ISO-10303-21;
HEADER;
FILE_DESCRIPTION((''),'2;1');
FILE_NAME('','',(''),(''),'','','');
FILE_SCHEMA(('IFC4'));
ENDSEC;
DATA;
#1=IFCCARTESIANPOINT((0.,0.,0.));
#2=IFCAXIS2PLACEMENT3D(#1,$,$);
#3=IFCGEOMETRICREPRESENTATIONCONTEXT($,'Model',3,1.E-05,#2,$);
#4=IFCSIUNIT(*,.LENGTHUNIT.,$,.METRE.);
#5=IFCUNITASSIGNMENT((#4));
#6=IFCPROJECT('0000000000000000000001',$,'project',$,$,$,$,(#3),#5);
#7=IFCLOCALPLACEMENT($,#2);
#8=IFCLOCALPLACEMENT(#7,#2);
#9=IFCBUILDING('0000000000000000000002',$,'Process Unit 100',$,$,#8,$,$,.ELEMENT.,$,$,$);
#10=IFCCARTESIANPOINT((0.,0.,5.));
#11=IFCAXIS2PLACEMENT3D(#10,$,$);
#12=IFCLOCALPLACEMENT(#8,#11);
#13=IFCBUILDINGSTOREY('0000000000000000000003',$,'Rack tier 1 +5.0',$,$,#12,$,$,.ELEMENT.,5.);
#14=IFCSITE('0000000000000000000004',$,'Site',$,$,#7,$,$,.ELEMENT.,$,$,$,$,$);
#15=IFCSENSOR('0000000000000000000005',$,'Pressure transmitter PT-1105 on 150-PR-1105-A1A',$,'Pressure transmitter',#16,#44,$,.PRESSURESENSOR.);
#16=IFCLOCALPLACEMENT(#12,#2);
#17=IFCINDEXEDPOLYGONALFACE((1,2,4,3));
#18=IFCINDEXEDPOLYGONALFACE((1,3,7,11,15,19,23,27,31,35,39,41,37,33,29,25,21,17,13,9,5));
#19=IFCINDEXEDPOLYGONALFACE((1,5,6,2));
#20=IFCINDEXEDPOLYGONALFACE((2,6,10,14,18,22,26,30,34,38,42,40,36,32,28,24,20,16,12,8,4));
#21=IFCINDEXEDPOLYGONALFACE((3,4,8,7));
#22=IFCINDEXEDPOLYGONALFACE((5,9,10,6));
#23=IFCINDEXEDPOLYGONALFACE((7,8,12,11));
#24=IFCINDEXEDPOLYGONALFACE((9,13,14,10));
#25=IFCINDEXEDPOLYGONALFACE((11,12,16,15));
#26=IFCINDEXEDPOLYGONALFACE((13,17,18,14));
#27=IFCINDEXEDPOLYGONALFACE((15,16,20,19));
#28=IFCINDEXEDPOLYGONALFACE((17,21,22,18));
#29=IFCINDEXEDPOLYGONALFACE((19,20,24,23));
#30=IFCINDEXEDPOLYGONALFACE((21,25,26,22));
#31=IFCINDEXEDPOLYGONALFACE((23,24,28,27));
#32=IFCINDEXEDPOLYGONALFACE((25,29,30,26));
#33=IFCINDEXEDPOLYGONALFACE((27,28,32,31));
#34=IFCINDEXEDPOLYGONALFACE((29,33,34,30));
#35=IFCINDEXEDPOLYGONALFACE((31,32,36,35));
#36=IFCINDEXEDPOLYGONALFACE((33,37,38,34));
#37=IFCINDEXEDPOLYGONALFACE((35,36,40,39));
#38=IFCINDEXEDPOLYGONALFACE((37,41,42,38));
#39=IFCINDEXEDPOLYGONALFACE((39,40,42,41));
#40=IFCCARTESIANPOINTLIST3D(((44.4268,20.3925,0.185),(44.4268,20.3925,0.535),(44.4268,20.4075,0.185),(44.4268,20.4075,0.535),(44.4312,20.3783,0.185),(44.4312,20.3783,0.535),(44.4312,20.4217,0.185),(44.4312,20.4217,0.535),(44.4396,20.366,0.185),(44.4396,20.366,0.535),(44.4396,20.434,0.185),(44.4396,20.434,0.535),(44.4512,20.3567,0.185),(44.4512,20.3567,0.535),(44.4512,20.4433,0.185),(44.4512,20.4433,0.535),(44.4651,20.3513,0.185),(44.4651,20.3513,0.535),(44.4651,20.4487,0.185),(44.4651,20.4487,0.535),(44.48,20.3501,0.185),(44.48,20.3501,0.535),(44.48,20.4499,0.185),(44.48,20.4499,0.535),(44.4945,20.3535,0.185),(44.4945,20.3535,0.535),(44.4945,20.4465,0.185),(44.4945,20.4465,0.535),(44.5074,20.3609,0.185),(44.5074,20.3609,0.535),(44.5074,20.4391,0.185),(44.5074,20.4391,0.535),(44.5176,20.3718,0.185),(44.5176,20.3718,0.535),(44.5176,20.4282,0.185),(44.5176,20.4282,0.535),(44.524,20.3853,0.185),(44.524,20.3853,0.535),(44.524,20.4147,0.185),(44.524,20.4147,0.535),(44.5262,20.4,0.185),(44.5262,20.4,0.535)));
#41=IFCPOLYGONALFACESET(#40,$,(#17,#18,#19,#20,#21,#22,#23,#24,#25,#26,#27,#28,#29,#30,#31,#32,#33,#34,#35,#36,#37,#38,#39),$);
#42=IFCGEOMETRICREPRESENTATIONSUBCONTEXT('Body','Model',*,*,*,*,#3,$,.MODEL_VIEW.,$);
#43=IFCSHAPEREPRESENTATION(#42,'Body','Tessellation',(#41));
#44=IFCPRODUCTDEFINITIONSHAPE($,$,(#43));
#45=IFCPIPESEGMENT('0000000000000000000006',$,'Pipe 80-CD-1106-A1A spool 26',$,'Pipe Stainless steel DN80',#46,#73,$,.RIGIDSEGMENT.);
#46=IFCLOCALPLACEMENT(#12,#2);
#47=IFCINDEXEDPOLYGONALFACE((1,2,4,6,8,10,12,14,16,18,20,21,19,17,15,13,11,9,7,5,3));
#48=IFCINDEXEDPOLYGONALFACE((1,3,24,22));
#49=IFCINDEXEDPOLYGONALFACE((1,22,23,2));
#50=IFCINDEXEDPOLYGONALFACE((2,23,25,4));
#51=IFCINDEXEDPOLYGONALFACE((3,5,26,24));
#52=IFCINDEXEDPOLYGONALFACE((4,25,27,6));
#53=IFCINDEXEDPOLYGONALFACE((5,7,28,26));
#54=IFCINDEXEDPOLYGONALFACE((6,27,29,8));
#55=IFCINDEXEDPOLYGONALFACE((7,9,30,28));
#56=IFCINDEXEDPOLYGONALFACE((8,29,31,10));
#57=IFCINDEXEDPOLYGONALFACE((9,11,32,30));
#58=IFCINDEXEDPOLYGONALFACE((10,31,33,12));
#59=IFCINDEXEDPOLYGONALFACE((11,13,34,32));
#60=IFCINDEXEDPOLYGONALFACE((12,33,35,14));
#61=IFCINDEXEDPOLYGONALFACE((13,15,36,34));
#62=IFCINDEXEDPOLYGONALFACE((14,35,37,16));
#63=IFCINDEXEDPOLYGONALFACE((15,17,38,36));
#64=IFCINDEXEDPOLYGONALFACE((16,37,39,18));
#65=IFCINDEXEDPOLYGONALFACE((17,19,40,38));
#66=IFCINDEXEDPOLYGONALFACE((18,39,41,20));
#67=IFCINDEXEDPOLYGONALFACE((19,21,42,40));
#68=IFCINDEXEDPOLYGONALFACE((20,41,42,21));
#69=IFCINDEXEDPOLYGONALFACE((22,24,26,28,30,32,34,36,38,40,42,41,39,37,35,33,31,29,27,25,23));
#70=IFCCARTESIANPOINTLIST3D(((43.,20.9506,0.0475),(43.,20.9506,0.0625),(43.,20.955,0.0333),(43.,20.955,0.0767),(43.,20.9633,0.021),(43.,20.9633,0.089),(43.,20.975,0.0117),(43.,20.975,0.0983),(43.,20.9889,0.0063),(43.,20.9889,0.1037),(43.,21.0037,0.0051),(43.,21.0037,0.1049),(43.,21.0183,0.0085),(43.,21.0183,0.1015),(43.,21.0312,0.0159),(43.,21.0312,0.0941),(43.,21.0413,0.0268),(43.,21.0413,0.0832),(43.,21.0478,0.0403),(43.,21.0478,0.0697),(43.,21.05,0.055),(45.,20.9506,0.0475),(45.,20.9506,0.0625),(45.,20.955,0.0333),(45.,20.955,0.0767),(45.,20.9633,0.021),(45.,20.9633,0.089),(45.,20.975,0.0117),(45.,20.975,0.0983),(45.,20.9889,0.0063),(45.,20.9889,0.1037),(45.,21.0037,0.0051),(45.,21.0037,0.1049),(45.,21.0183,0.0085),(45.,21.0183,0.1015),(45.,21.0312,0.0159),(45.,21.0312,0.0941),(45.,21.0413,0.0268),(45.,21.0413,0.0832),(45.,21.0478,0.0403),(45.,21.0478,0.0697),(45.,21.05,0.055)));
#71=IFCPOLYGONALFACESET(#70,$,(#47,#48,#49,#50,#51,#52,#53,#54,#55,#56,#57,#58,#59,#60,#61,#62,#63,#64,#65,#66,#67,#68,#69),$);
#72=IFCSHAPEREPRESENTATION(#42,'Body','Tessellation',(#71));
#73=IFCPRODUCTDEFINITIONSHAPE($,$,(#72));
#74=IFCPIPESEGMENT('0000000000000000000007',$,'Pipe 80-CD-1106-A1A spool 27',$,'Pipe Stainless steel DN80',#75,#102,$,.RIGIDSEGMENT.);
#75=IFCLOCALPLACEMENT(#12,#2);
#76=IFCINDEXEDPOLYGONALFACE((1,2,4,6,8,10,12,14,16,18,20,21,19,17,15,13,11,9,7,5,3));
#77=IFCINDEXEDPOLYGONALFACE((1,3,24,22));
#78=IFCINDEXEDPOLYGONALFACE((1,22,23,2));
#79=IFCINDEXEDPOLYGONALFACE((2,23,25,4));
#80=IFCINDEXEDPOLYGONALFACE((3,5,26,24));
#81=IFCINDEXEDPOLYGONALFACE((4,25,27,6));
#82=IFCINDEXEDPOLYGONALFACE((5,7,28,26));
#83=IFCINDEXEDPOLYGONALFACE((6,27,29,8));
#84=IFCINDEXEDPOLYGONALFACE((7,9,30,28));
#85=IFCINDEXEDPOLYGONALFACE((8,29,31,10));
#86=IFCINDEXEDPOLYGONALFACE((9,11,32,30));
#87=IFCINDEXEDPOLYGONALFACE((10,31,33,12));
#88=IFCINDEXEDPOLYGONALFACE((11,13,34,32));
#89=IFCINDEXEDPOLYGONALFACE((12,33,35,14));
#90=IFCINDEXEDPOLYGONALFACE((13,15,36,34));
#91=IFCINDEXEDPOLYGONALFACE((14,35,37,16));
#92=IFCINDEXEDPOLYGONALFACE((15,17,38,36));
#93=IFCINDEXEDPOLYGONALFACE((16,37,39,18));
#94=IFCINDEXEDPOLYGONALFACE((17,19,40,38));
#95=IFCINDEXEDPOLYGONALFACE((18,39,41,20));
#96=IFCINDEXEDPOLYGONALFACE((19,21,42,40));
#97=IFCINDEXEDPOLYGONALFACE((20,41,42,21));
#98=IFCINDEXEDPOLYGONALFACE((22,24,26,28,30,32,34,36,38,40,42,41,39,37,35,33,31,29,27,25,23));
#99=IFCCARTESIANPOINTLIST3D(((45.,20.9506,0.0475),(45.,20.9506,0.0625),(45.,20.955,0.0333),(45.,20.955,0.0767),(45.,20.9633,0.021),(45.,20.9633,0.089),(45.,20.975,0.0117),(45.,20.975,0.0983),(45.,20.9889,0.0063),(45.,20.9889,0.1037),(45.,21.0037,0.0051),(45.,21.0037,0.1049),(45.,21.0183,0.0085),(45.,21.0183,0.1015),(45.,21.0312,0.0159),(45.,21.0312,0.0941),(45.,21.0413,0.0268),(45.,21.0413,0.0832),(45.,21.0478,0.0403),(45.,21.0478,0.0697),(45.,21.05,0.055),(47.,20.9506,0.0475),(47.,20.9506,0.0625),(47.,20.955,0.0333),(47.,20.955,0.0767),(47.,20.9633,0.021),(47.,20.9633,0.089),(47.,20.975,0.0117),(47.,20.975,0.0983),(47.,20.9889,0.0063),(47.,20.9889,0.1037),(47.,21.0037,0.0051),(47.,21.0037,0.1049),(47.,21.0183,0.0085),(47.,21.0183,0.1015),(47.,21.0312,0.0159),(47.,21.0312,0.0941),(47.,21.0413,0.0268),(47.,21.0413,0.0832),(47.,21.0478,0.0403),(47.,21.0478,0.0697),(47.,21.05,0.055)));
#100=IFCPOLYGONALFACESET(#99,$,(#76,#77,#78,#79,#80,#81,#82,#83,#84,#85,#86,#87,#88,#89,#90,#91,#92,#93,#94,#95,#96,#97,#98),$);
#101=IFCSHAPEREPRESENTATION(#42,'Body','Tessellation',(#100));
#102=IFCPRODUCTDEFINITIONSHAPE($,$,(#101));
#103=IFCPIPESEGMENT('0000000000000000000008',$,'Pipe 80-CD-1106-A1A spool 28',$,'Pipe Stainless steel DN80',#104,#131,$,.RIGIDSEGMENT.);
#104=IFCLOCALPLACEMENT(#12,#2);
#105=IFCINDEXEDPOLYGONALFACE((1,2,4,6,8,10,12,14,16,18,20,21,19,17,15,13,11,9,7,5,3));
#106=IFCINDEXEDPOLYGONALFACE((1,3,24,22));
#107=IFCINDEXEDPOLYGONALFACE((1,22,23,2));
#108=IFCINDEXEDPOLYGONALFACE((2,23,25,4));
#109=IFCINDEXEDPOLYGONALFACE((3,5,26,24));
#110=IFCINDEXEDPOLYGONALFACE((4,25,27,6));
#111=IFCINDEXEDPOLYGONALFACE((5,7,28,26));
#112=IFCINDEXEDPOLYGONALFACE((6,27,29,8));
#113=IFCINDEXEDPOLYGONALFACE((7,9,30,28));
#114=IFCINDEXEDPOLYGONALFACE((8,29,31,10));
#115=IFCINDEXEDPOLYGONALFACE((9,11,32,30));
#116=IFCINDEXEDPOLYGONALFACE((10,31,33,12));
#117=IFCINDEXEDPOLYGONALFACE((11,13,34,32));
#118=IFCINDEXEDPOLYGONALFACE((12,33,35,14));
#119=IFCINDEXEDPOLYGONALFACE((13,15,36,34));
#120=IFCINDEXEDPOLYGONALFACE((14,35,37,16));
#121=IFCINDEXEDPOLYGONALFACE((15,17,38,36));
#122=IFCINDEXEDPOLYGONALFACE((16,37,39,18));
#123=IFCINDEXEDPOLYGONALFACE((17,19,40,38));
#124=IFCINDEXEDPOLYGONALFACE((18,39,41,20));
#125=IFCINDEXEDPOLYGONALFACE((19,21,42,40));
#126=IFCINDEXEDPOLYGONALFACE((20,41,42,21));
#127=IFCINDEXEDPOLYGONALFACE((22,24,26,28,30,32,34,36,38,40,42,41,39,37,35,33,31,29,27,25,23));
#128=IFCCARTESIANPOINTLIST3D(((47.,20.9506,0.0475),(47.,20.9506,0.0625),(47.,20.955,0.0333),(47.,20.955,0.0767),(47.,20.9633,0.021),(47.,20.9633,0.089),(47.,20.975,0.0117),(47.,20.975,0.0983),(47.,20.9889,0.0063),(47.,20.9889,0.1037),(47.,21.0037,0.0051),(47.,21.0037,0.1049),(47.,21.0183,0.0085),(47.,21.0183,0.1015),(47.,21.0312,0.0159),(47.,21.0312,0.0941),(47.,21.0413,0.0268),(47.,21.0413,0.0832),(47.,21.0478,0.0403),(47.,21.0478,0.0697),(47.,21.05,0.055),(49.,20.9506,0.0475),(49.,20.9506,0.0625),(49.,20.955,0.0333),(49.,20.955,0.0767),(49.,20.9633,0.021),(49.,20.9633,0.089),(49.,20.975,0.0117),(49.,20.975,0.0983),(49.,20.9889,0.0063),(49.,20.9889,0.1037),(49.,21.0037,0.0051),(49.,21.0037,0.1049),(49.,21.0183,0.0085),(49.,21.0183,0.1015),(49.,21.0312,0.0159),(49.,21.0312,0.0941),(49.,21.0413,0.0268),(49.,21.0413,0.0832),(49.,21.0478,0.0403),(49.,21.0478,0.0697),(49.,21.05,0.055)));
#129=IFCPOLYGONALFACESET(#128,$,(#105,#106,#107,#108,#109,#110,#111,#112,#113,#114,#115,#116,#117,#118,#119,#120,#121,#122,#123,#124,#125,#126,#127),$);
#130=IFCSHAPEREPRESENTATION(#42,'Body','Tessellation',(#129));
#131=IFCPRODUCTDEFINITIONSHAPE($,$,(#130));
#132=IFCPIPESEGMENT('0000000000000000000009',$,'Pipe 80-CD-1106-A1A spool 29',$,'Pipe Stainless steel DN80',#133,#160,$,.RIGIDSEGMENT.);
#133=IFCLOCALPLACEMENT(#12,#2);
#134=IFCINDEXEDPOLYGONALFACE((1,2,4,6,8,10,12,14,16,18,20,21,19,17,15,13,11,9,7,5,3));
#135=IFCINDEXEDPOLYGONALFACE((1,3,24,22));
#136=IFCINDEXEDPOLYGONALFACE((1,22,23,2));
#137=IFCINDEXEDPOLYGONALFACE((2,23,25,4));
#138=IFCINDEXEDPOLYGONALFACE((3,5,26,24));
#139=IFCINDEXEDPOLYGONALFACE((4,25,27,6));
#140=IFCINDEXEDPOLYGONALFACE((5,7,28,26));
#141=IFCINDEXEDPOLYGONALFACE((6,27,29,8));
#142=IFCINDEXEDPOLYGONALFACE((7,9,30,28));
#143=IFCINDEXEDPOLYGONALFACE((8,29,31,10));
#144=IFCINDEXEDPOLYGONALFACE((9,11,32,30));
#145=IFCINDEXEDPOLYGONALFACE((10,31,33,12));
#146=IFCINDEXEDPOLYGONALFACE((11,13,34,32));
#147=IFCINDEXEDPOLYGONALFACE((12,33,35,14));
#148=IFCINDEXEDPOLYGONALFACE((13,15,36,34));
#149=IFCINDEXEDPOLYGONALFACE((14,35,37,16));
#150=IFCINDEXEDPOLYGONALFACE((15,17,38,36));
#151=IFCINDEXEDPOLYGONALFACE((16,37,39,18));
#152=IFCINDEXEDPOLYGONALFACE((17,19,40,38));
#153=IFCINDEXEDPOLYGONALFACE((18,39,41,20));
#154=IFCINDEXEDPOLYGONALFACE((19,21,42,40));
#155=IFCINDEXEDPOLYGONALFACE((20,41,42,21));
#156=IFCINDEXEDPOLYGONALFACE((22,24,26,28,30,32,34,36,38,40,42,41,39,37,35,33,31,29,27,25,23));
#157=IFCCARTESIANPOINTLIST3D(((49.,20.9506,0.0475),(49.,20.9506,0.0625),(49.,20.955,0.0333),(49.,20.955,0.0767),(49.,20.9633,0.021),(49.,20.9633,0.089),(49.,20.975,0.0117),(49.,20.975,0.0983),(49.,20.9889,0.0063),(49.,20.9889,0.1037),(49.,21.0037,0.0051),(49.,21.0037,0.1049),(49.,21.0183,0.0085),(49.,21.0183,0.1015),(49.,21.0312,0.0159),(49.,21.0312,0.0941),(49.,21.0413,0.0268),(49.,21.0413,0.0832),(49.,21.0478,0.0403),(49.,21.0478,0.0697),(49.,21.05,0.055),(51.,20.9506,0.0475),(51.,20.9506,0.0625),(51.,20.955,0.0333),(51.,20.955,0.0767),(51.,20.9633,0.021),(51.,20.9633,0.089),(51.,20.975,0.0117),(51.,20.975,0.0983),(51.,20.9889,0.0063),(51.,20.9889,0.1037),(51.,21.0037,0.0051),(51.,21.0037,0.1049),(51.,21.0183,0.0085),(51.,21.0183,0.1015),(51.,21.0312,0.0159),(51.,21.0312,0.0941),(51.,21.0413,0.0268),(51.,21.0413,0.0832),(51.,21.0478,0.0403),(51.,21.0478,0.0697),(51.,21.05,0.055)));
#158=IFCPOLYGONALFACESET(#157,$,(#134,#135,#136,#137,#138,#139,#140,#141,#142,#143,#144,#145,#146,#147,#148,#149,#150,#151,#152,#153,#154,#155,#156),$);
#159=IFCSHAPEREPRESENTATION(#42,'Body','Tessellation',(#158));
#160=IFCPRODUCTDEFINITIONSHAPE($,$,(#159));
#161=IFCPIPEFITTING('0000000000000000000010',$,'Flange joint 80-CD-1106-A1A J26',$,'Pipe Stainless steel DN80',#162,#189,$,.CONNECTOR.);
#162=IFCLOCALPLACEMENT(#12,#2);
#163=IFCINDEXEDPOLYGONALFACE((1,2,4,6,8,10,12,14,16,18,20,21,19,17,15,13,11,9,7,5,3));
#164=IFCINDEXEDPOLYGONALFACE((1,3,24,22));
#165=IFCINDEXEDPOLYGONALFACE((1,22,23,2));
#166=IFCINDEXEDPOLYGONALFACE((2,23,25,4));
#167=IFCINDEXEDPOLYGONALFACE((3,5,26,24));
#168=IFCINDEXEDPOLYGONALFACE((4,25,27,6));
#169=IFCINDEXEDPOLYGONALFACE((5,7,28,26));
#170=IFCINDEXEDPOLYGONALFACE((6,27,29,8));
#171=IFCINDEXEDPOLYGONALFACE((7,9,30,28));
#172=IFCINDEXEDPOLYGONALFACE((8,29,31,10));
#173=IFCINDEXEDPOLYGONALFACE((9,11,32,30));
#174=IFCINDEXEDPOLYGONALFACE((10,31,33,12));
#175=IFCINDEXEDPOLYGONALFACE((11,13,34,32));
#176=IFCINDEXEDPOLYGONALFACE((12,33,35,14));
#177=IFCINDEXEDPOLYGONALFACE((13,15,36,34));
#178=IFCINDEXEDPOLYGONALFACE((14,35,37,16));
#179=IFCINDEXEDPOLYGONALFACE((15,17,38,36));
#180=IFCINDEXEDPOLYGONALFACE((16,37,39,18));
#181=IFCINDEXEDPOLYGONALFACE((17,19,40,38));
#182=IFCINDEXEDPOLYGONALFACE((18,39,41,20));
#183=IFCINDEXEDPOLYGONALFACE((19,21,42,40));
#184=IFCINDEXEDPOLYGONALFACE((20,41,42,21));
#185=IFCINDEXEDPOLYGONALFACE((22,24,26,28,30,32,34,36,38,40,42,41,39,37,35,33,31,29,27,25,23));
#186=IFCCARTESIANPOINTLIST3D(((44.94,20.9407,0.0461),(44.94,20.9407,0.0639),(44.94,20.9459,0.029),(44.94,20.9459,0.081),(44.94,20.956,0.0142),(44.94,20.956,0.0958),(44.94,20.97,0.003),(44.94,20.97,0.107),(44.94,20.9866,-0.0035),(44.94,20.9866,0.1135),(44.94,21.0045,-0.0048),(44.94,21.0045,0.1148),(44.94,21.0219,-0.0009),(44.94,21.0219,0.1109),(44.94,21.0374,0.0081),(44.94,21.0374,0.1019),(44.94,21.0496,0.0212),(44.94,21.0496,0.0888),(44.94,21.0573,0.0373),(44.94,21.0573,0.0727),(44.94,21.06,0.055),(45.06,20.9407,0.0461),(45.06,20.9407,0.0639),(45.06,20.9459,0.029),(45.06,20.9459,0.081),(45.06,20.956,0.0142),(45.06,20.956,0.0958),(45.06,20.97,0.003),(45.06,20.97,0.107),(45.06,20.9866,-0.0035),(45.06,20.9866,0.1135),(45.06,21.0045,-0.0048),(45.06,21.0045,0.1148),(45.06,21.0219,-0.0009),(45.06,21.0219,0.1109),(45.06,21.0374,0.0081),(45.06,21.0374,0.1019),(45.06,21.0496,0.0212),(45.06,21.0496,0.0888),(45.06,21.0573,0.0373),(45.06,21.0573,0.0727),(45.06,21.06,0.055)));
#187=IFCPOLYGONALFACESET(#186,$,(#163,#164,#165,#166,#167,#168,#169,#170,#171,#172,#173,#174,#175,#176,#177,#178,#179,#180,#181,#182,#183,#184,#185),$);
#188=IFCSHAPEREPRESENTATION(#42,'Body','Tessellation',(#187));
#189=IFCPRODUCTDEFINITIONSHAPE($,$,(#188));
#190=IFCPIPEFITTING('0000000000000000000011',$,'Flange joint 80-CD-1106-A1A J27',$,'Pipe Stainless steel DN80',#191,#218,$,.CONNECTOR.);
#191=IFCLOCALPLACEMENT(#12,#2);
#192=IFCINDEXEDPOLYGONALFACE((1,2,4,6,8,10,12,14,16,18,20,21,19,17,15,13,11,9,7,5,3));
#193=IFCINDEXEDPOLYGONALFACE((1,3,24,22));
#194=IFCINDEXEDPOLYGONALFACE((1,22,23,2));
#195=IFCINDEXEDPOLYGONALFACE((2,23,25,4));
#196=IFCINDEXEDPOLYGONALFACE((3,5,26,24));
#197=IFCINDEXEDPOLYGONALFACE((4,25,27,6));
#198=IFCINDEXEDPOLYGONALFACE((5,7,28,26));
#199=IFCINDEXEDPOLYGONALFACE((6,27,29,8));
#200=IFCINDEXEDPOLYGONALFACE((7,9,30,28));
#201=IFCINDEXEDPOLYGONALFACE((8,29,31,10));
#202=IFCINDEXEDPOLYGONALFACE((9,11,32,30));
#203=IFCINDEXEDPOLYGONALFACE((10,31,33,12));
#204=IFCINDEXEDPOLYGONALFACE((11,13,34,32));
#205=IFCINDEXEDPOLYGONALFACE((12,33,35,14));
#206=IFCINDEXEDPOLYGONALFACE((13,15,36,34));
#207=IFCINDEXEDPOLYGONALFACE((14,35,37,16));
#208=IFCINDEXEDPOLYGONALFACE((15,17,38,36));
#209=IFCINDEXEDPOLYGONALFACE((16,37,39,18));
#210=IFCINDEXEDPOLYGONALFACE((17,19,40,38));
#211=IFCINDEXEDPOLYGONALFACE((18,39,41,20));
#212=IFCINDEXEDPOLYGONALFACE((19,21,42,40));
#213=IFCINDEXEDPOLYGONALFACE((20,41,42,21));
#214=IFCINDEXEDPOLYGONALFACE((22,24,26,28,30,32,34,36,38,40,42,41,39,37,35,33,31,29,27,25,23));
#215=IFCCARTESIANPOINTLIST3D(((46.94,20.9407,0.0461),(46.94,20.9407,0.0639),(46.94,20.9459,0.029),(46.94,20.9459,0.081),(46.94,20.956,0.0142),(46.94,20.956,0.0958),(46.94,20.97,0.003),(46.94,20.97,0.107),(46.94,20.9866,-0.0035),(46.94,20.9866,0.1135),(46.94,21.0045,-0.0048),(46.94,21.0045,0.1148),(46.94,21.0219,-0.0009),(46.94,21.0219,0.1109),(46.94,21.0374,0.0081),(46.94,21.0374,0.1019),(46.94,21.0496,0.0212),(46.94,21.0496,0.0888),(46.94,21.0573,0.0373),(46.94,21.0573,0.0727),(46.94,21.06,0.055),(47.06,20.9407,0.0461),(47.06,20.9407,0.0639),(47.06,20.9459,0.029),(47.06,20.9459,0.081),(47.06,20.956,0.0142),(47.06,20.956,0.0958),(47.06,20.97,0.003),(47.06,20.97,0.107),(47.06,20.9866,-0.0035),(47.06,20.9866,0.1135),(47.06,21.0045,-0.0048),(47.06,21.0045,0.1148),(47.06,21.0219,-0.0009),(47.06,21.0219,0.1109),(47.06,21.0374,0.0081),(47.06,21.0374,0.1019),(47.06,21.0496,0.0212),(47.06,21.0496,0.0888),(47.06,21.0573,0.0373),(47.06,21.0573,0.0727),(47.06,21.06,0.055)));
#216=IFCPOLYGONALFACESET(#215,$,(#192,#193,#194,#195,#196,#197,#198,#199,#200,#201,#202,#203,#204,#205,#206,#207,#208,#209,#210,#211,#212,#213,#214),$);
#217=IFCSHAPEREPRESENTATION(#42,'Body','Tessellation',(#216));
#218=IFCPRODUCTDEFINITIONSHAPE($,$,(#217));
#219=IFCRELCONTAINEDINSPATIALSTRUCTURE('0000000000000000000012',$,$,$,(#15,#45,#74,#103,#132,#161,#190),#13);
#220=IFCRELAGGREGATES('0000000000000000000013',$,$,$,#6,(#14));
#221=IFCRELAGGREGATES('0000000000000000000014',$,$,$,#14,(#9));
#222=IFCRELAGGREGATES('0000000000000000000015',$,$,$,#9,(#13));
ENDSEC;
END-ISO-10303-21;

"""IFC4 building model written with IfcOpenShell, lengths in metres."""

from ifc_helpers import new_model, si_unit, frame, origin, place, context, subcontext, project, spatial, circle, extrude, element, save


model = new_model("IFC4")

# Units and contexts
model_context = context("Model", 3, precision=1e-05, world=origin())
body_context = subcontext(model_context, "Body", "Model", "MODEL_VIEW")
ifc_project = project(units=[si_unit("LENGTHUNIT", "METRE")], contexts=[model_context])

# Site, building, storey
site_placement = place(None, origin())
site = spatial("IfcSite", under=ifc_project, at=site_placement, Name="Site", CompositionType="ELEMENT")
building_placement = place(site_placement, origin())
building = spatial("IfcBuilding", under=site, at=building_placement, Name="Process Unit 100", CompositionType="ELEMENT")
storey_placement = place(building_placement, frame((0.0, 0.0, 5.0)))
storey = spatial("IfcBuildingStorey", under=building, at=storey_placement, Name="Rack tier 1 +5.0", CompositionType="ELEMENT", Elevation=5.0)

# Sensor
sensor_1_placement = place(storey_placement, frame((44.4763, 20.4, 0.185), z_axis=(0.0, 0.0, 1.0), x_axis=(1.0, 0.0, 0.0)))
element("IfcSensor", 1, at=sensor_1_placement, inside=storey, Name="Pressure transmitter PT-1105 on 150-PR-1105-A1A", ObjectType="Pressure transmitter", PredefinedType="PRESSURESENSOR", context=body_context, shape_type="SweptSolid", body=[
    extrude(circle(Radius=0.05), origin(), (0.0, 0.0, 1.0), 0.35),
])

# Pipe segments
for number, where, z_axis, x_axis, name in (
    (2, (43.0, 21.0, 0.055), (1.0, 0.0, 0.0), (0.0, 1.0, 0.0), "Pipe 80-CD-1106-A1A spool 26"),
    (3, (45.0, 21.0, 0.055), (1.0, 0.0, 0.0), (0.0, 1.0, 0.0), "Pipe 80-CD-1106-A1A spool 27"),
    (4, (47.0, 21.0, 0.055), (1.0, 0.0, 0.0), (0.0, 1.0, 0.0), "Pipe 80-CD-1106-A1A spool 28"),
    (5, (49.0, 21.0, 0.055), (1.0, 0.0, 0.0), (0.0, 1.0, 0.0), "Pipe 80-CD-1106-A1A spool 29"),
):
    element("IfcPipeSegment", number, at=place(storey_placement, frame(where, z_axis=z_axis, x_axis=x_axis)), inside=storey, Name=name, ObjectType="Pipe Stainless steel DN80", PredefinedType="RIGIDSEGMENT", context=body_context, shape_type="SweptSolid", body=[
        extrude(circle(Radius=0.05), origin(), (0.0, 0.0, 1.0), 2.0),
    ])

# Pipe fittings
for number, where, z_axis, x_axis, name in (
    (6, (44.94, 21.0, 0.055), (1.0, 0.0, 0.0), (0.0, 1.0, 0.0), "Flange joint 80-CD-1106-A1A J26"),
    (7, (46.94, 21.0, 0.055), (1.0, 0.0, 0.0), (0.0, 1.0, 0.0), "Flange joint 80-CD-1106-A1A J27"),
):
    element("IfcPipeFitting", number, at=place(storey_placement, frame(where, z_axis=z_axis, x_axis=x_axis)), inside=storey, Name=name, ObjectType="Pipe Stainless steel DN80", PredefinedType="CONNECTOR", context=body_context, shape_type="SweptSolid", body=[
        extrude(circle(Radius=0.06), origin(), (0.0, 0.0, 1.0), 0.12),
    ])

save(model, "model.ifc")
